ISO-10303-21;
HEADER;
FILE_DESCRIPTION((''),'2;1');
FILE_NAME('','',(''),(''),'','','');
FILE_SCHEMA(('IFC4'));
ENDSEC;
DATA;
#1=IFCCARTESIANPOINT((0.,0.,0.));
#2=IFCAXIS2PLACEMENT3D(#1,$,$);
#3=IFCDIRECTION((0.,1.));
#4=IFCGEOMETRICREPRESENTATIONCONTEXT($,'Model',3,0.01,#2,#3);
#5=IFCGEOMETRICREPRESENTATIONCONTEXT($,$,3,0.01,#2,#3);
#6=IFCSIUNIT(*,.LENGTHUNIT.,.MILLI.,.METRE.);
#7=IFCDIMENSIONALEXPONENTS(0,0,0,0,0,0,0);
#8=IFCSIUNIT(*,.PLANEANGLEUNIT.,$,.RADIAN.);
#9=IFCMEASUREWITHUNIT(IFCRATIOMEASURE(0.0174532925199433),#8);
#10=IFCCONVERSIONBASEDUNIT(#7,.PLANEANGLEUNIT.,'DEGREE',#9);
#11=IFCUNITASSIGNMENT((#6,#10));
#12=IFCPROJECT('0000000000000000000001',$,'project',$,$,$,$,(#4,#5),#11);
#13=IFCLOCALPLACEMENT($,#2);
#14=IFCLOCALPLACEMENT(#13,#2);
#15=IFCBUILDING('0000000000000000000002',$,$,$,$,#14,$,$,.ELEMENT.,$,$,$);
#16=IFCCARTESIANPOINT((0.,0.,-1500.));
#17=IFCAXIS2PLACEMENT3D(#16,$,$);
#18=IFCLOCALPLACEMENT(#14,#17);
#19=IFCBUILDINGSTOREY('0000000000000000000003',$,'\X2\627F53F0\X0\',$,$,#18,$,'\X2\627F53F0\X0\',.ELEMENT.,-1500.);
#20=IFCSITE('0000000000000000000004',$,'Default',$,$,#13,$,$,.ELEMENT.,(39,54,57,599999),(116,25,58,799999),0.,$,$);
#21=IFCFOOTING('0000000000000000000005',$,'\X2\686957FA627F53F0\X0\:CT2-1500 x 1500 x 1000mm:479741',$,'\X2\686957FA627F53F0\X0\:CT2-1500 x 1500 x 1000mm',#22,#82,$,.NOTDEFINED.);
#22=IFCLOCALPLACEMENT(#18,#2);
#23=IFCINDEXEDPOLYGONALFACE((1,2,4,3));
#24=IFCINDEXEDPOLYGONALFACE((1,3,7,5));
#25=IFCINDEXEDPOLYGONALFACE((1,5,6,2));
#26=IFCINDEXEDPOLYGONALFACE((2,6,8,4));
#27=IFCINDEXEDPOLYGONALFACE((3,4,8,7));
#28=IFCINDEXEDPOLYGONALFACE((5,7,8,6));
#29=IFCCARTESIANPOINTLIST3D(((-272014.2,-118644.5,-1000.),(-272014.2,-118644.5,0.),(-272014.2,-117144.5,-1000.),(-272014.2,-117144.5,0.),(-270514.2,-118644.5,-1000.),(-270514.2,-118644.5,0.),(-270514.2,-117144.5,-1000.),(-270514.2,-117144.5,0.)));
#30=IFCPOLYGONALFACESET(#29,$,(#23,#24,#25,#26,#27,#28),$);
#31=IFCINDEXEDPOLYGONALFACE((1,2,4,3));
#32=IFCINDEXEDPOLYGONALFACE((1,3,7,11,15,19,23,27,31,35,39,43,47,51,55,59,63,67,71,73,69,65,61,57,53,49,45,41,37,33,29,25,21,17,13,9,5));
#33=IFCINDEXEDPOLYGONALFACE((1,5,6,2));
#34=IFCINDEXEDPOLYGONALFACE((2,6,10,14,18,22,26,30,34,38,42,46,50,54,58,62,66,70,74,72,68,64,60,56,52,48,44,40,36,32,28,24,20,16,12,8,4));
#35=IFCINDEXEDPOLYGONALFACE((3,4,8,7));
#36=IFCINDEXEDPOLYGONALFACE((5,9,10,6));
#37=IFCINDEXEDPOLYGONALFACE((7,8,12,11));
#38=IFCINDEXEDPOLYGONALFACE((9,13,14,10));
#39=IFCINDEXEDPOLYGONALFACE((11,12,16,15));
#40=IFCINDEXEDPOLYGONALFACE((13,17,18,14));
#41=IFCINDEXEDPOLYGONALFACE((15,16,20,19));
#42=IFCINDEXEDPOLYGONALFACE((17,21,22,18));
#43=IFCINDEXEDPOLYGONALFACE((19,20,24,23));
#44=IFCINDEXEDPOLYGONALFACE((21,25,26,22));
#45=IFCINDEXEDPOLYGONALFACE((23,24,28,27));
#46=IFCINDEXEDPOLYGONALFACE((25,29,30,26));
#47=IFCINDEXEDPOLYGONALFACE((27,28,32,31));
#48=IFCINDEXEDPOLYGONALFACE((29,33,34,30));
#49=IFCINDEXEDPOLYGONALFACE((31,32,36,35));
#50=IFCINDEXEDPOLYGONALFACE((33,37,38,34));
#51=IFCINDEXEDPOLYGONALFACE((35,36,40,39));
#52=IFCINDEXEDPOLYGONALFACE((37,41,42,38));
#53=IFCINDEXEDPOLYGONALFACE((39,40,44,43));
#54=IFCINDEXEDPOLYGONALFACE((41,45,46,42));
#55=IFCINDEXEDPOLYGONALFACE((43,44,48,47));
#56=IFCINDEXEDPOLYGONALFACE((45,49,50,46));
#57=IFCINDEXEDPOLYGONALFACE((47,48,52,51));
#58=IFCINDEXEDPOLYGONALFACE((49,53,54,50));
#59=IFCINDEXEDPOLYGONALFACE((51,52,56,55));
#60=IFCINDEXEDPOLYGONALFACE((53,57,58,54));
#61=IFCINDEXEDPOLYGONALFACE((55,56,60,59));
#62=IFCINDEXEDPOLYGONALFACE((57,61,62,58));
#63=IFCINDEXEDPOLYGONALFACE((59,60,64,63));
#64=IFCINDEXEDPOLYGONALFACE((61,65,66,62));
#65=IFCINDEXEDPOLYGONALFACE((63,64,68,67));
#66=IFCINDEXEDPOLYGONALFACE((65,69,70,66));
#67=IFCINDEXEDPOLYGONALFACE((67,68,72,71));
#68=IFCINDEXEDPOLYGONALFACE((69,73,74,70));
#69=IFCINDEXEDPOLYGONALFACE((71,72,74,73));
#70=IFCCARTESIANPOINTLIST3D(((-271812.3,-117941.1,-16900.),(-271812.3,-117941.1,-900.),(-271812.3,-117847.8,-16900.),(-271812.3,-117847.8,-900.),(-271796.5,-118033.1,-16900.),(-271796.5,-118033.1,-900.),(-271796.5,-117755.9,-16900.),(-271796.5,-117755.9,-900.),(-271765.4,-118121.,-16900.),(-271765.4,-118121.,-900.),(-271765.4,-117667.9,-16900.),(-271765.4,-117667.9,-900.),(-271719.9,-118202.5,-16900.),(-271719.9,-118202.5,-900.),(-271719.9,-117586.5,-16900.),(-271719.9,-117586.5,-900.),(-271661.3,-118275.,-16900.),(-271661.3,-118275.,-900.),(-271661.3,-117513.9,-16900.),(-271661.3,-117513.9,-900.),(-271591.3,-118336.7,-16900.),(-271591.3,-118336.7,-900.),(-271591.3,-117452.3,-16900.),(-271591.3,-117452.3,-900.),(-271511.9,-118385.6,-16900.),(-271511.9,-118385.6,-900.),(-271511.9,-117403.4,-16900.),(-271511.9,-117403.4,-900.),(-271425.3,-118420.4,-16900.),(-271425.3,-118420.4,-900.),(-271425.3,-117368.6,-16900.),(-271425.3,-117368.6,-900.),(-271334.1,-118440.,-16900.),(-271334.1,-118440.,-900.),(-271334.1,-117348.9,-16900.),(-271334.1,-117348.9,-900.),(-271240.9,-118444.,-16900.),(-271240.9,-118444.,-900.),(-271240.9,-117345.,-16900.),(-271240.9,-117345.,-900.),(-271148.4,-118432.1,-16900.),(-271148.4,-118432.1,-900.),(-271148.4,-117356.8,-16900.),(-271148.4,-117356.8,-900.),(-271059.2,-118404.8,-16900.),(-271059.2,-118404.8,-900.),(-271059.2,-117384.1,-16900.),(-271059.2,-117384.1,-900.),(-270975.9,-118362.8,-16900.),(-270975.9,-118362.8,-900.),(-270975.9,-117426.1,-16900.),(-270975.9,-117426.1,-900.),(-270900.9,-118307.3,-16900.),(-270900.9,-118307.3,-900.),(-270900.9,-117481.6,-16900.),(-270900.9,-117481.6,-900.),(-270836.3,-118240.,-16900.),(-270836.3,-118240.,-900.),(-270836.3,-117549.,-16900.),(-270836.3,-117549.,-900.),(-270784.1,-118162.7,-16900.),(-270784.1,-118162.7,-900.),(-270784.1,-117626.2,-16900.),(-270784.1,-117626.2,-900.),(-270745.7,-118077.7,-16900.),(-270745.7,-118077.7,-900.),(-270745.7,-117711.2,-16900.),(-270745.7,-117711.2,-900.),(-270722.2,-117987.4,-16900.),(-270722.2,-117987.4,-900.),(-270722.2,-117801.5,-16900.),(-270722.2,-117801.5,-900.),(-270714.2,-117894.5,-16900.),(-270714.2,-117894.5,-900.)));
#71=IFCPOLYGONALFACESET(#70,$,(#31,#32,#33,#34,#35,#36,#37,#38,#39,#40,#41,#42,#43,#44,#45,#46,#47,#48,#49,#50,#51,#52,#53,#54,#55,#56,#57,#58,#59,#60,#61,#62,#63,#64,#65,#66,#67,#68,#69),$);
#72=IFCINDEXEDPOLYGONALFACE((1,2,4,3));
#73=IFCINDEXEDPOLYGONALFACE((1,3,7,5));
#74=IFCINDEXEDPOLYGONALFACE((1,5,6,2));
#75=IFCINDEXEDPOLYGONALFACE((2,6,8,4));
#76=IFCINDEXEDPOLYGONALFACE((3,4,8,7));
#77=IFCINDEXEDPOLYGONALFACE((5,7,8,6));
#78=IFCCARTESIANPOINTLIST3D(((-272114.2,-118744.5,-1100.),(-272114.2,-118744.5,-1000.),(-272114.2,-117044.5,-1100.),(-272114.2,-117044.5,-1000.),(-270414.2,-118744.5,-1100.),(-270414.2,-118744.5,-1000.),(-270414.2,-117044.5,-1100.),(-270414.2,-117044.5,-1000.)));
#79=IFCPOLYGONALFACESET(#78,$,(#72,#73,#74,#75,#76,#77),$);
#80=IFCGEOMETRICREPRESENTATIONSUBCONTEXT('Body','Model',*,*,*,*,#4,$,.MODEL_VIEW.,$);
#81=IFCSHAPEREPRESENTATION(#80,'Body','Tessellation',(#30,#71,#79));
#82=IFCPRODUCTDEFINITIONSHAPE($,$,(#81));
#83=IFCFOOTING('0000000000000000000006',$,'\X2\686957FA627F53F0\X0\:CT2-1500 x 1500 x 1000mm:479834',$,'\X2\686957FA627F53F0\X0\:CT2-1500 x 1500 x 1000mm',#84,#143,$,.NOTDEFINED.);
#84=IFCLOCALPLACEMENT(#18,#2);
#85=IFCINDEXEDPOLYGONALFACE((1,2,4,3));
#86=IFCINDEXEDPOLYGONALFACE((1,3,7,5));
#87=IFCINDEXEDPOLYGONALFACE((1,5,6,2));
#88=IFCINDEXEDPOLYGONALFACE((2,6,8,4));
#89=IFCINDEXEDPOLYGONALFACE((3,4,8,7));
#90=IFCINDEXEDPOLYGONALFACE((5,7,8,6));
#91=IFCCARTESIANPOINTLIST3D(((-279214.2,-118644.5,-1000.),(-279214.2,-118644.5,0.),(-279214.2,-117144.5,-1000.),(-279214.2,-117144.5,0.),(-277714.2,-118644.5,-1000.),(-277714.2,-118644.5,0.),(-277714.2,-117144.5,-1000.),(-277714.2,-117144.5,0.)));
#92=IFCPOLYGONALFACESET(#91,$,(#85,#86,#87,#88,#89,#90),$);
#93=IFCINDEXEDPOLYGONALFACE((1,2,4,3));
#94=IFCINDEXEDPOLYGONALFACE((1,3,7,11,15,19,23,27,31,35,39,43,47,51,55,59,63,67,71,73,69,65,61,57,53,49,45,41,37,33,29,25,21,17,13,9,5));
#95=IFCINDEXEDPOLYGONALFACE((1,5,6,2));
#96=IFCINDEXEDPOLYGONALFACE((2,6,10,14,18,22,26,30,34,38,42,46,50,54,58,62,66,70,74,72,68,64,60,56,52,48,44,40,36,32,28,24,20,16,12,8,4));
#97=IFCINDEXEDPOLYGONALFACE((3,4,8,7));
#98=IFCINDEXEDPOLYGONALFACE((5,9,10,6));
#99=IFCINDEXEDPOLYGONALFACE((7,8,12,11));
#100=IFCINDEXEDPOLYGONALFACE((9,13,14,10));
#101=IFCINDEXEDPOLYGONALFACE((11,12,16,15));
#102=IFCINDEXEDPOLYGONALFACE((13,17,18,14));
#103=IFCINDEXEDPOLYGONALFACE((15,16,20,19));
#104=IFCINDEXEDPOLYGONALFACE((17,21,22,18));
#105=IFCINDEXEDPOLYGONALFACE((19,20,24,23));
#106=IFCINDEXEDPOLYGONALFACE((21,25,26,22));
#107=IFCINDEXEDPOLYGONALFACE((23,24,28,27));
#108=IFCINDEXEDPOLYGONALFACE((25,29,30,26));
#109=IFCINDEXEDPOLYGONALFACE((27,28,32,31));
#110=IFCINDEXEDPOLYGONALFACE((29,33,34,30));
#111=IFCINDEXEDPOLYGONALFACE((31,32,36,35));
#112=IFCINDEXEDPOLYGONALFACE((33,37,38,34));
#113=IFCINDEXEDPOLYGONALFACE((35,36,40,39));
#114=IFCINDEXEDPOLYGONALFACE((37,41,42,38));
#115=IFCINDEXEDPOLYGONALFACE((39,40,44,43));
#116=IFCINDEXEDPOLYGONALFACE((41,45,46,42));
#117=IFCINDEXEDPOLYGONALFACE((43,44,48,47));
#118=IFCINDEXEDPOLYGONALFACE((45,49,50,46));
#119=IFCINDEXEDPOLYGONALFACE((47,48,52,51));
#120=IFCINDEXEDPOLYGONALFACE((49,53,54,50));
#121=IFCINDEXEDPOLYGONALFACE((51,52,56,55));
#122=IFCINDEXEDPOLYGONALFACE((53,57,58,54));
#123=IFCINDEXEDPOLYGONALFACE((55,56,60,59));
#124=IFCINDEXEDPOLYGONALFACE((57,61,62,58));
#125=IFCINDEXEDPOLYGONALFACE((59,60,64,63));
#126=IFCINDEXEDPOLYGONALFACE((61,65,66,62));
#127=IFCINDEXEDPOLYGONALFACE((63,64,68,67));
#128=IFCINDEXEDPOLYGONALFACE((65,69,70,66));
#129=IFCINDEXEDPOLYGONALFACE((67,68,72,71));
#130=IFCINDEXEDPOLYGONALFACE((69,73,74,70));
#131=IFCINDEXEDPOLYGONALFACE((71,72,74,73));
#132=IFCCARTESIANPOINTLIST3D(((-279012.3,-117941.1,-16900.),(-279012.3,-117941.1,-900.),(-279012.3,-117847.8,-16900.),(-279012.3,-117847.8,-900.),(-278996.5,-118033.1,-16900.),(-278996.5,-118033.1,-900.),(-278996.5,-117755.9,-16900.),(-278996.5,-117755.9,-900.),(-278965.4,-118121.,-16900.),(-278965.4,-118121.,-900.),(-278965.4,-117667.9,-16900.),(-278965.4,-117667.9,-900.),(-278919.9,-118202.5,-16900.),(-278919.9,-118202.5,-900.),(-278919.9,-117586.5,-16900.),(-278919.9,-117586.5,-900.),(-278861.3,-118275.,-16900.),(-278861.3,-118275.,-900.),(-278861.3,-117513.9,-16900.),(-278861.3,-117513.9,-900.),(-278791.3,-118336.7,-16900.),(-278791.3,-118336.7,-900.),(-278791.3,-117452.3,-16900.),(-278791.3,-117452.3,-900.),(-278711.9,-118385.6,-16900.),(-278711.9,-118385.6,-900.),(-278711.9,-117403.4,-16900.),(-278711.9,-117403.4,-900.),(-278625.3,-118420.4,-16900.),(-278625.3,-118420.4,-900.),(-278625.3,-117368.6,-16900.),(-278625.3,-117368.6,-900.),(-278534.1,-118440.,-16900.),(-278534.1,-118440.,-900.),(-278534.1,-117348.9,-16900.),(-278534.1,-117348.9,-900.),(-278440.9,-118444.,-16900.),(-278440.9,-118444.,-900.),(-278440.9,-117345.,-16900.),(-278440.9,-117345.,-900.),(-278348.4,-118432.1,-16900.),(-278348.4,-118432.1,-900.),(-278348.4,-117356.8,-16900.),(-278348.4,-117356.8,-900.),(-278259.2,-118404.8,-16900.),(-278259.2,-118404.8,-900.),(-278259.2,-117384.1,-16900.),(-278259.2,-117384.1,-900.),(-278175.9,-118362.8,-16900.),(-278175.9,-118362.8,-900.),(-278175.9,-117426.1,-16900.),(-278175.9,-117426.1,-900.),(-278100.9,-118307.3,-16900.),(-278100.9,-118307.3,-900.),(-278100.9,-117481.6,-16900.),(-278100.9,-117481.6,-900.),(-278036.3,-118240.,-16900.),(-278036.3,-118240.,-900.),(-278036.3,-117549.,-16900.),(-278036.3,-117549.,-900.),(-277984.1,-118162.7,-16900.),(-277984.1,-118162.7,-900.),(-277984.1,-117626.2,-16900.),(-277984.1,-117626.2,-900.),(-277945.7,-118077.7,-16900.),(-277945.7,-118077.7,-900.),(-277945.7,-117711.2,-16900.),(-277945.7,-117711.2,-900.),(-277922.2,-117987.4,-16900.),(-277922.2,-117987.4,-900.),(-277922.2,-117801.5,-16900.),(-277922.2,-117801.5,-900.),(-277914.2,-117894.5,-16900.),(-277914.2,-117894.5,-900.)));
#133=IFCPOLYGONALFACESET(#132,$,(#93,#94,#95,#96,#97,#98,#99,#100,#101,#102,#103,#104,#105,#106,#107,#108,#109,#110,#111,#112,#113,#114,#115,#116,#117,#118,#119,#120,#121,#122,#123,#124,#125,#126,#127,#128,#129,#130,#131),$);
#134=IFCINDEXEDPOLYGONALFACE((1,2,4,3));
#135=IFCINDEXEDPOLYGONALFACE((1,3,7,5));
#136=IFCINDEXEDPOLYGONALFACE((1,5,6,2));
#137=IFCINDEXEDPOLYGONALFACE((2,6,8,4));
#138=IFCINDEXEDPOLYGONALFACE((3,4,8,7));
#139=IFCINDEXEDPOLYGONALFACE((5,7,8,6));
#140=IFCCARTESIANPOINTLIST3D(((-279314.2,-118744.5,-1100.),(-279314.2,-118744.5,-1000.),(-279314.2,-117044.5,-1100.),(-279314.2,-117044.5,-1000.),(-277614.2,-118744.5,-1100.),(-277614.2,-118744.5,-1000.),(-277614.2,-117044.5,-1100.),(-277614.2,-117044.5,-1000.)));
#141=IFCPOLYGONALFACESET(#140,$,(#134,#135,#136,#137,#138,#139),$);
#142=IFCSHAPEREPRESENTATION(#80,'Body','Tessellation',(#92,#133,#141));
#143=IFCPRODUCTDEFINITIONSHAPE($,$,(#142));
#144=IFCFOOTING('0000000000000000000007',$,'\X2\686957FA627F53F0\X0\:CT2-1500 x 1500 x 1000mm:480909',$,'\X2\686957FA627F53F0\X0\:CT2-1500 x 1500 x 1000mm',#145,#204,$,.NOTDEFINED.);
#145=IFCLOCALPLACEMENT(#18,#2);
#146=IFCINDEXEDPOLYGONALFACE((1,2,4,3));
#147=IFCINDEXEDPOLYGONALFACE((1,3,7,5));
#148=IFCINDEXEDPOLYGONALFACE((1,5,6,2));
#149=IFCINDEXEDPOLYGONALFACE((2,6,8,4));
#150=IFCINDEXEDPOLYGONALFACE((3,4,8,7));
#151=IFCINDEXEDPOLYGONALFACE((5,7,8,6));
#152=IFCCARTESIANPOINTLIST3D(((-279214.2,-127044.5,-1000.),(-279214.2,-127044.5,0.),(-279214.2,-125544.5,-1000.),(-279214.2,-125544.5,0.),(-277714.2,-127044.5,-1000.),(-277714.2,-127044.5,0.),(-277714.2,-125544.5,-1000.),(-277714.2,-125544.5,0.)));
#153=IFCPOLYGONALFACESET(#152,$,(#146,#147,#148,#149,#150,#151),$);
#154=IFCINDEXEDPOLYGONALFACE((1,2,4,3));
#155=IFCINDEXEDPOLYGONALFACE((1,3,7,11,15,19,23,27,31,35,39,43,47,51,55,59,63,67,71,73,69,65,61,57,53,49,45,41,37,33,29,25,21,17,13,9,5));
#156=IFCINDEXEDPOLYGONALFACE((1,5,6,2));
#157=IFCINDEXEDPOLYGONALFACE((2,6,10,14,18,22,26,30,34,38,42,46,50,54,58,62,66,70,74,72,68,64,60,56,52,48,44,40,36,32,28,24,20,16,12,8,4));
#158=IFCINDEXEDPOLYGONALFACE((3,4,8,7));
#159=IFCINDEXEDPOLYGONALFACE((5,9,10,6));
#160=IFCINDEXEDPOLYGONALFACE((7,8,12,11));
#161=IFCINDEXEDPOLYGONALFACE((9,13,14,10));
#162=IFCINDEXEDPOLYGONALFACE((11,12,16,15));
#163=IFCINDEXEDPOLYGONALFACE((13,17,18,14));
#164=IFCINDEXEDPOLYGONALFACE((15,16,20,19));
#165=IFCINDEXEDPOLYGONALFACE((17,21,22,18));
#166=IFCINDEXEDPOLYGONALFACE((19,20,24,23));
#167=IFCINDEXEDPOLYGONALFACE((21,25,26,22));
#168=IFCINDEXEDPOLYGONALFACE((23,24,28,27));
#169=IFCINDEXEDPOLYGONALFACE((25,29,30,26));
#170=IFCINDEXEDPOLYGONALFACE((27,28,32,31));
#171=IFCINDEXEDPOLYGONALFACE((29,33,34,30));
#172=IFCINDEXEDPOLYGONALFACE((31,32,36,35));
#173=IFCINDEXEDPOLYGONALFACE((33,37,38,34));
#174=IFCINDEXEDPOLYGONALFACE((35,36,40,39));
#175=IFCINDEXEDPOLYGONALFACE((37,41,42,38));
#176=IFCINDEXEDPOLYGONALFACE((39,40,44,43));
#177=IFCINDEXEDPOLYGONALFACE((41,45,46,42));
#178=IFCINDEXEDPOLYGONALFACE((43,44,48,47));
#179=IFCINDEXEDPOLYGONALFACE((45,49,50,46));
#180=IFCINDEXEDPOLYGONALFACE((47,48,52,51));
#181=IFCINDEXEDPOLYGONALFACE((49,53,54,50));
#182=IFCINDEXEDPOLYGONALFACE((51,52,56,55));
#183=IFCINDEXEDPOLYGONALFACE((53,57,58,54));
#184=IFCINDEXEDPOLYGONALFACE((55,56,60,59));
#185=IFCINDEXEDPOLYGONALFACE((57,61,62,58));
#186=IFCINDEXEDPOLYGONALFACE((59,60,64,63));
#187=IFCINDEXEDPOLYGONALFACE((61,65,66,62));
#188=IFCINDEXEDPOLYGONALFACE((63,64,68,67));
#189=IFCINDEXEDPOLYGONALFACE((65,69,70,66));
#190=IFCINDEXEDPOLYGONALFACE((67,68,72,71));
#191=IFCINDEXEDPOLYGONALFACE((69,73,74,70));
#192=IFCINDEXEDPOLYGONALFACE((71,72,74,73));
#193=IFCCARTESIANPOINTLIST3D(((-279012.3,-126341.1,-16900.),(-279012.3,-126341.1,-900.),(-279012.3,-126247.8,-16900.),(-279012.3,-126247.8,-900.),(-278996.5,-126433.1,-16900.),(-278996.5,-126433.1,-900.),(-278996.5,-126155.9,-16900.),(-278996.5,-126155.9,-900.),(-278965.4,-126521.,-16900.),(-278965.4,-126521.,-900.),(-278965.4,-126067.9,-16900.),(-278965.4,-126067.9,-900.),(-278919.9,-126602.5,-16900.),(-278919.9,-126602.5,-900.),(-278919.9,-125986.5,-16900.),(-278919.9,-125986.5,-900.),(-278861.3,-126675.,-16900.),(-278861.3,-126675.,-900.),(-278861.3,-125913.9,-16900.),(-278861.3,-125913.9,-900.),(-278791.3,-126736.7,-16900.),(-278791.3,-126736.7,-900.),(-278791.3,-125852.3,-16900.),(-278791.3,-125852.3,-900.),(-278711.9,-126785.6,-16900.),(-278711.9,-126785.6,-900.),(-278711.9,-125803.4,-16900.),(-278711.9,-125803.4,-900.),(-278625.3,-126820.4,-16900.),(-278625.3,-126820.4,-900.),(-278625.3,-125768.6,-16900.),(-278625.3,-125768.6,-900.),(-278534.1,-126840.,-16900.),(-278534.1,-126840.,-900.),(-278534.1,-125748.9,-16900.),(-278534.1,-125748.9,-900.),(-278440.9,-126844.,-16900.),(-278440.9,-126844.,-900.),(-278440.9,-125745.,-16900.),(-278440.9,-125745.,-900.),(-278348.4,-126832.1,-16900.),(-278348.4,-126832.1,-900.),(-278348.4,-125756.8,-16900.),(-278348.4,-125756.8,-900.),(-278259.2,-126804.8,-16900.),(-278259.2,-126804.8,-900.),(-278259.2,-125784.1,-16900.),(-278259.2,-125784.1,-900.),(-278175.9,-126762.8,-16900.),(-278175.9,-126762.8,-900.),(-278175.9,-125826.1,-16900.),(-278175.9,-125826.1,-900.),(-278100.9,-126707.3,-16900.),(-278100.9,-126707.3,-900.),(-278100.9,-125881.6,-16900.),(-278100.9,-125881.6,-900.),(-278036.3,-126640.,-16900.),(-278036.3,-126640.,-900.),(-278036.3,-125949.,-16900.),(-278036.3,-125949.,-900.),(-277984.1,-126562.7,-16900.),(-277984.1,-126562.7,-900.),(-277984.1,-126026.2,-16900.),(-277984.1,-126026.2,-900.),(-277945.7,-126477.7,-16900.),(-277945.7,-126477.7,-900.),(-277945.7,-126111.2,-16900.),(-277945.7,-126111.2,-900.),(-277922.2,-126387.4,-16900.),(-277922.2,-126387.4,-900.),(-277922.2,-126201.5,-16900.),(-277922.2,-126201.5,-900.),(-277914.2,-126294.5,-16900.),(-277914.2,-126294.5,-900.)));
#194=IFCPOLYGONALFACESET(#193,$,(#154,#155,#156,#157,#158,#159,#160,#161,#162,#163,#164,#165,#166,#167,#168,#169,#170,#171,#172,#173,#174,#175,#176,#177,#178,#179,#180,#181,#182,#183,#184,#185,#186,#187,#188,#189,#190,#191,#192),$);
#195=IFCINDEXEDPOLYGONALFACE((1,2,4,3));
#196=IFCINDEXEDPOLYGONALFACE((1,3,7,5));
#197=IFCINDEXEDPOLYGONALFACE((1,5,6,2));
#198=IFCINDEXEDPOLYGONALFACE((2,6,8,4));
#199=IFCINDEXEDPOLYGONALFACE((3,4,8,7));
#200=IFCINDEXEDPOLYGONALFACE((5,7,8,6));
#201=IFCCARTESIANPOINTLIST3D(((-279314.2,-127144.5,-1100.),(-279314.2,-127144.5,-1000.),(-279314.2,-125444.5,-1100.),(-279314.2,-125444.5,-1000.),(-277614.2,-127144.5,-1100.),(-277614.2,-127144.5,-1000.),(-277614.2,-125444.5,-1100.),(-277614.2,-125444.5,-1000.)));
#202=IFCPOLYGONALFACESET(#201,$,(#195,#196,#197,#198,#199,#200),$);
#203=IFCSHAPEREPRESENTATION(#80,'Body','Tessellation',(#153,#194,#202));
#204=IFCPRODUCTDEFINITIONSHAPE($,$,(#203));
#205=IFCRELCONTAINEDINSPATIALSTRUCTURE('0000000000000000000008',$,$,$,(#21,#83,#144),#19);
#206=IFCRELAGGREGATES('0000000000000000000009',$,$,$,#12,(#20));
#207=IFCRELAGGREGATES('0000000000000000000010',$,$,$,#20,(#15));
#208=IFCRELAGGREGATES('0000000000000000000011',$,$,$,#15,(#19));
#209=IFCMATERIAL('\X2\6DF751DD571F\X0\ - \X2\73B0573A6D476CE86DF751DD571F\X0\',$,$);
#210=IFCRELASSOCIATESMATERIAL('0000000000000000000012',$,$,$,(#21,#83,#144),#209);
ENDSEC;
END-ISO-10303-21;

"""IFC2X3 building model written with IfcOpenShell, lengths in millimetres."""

from ifc_helpers import new_model, entity, si_unit, converted_unit, direction, frame, frame_2d, origin, origin_2d_with_axis, place, context, subcontext, project, spatial, rectangle, circle, extrude, material, element, save


model = new_model("IFC2X3")

# Units and contexts
model_context = context("Model", 3, precision=0.01, world=origin(), true_north=direction((0.0, 1.0)))
context_of_model = context(None, 3, precision=0.01, world=origin(), true_north=direction((0.0, 1.0)))
body_context = subcontext(model_context, "Body", "Model", "MODEL_VIEW")
ifc_project = project(units=[si_unit("LENGTHUNIT", "METRE", prefix="MILLI"), converted_unit("PLANEANGLEUNIT", "DEGREE", entity("IfcRatioMeasure", 0.0174532925199433), si_unit("PLANEANGLEUNIT", "RADIAN"), dimensions=[0, 0, 0, 0, 0, 0, 0])], contexts=[model_context, context_of_model])

# Site, building, storey
site_placement = place(None, origin())
site = spatial("IfcSite", under=ifc_project, at=site_placement, Name="Default", CompositionType="ELEMENT", RefLatitude=(39, 54, 57, 599999), RefLongitude=(116, 25, 58, 799999), RefElevation=0.0)
building_placement = place(site_placement, origin())
building = spatial("IfcBuilding", under=site, at=building_placement, CompositionType="ELEMENT")
storey_placement = place(building_placement, frame((0.0, 0.0, -1500.0)))
storey = spatial("IfcBuildingStorey", under=building, at=storey_placement, Name="承台", LongName="承台", CompositionType="ELEMENT", Elevation=-1500.0)

# Footings
ifc_material_1 = material(Name="混凝土 - 现场浇注混凝土")
for number, where, name in (
    (1, (-272114.2, -118744.5, -16900.0), "桩基承台:CT2-1500 x 1500 x 1000mm:479741"),
    (2, (-279314.2, -118744.5, -16900.0), "桩基承台:CT2-1500 x 1500 x 1000mm:479834"),
    (3, (-279314.2, -127144.5, -16900.0), "桩基承台:CT2-1500 x 1500 x 1000mm:480909"),
):
    element("IfcFooting", number, at=place(storey_placement, frame(where)), inside=storey, material=ifc_material_1, Name=name, ObjectType="桩基承台:CT2-1500 x 1500 x 1000mm", PredefinedType="NOTDEFINED", context=body_context, shape_type="SweptSolid", body=[
        extrude(rectangle(XDim=1500.0, YDim=1500.0, at=origin_2d_with_axis()), frame((850.0, 850.0, 15900.0), z_axis=(0.0, 0.0, 1.0), x_axis=(-1.0, 0.0, 0.0)), (0.0, 0.0, 1.0), 1000.0),
        extrude(circle(Radius=550.0, at=origin_2d_with_axis()), frame((850.0, 850.0, 0.0)), (0.0, 0.0, 1.0), 16000.0),
        extrude(rectangle(XDim=1700.0, YDim=1700.0, at=frame_2d((0.0, 0.0), x_axis=(1.0, 0.0))), frame((850.0, 850.0, 15800.0), z_axis=(0.0, 0.0, 1.0), x_axis=(0.0, 1.0, 0.0)), (0.0, 0.0, 1.0), 100.0),
    ])

save(model, "model.ifc")
